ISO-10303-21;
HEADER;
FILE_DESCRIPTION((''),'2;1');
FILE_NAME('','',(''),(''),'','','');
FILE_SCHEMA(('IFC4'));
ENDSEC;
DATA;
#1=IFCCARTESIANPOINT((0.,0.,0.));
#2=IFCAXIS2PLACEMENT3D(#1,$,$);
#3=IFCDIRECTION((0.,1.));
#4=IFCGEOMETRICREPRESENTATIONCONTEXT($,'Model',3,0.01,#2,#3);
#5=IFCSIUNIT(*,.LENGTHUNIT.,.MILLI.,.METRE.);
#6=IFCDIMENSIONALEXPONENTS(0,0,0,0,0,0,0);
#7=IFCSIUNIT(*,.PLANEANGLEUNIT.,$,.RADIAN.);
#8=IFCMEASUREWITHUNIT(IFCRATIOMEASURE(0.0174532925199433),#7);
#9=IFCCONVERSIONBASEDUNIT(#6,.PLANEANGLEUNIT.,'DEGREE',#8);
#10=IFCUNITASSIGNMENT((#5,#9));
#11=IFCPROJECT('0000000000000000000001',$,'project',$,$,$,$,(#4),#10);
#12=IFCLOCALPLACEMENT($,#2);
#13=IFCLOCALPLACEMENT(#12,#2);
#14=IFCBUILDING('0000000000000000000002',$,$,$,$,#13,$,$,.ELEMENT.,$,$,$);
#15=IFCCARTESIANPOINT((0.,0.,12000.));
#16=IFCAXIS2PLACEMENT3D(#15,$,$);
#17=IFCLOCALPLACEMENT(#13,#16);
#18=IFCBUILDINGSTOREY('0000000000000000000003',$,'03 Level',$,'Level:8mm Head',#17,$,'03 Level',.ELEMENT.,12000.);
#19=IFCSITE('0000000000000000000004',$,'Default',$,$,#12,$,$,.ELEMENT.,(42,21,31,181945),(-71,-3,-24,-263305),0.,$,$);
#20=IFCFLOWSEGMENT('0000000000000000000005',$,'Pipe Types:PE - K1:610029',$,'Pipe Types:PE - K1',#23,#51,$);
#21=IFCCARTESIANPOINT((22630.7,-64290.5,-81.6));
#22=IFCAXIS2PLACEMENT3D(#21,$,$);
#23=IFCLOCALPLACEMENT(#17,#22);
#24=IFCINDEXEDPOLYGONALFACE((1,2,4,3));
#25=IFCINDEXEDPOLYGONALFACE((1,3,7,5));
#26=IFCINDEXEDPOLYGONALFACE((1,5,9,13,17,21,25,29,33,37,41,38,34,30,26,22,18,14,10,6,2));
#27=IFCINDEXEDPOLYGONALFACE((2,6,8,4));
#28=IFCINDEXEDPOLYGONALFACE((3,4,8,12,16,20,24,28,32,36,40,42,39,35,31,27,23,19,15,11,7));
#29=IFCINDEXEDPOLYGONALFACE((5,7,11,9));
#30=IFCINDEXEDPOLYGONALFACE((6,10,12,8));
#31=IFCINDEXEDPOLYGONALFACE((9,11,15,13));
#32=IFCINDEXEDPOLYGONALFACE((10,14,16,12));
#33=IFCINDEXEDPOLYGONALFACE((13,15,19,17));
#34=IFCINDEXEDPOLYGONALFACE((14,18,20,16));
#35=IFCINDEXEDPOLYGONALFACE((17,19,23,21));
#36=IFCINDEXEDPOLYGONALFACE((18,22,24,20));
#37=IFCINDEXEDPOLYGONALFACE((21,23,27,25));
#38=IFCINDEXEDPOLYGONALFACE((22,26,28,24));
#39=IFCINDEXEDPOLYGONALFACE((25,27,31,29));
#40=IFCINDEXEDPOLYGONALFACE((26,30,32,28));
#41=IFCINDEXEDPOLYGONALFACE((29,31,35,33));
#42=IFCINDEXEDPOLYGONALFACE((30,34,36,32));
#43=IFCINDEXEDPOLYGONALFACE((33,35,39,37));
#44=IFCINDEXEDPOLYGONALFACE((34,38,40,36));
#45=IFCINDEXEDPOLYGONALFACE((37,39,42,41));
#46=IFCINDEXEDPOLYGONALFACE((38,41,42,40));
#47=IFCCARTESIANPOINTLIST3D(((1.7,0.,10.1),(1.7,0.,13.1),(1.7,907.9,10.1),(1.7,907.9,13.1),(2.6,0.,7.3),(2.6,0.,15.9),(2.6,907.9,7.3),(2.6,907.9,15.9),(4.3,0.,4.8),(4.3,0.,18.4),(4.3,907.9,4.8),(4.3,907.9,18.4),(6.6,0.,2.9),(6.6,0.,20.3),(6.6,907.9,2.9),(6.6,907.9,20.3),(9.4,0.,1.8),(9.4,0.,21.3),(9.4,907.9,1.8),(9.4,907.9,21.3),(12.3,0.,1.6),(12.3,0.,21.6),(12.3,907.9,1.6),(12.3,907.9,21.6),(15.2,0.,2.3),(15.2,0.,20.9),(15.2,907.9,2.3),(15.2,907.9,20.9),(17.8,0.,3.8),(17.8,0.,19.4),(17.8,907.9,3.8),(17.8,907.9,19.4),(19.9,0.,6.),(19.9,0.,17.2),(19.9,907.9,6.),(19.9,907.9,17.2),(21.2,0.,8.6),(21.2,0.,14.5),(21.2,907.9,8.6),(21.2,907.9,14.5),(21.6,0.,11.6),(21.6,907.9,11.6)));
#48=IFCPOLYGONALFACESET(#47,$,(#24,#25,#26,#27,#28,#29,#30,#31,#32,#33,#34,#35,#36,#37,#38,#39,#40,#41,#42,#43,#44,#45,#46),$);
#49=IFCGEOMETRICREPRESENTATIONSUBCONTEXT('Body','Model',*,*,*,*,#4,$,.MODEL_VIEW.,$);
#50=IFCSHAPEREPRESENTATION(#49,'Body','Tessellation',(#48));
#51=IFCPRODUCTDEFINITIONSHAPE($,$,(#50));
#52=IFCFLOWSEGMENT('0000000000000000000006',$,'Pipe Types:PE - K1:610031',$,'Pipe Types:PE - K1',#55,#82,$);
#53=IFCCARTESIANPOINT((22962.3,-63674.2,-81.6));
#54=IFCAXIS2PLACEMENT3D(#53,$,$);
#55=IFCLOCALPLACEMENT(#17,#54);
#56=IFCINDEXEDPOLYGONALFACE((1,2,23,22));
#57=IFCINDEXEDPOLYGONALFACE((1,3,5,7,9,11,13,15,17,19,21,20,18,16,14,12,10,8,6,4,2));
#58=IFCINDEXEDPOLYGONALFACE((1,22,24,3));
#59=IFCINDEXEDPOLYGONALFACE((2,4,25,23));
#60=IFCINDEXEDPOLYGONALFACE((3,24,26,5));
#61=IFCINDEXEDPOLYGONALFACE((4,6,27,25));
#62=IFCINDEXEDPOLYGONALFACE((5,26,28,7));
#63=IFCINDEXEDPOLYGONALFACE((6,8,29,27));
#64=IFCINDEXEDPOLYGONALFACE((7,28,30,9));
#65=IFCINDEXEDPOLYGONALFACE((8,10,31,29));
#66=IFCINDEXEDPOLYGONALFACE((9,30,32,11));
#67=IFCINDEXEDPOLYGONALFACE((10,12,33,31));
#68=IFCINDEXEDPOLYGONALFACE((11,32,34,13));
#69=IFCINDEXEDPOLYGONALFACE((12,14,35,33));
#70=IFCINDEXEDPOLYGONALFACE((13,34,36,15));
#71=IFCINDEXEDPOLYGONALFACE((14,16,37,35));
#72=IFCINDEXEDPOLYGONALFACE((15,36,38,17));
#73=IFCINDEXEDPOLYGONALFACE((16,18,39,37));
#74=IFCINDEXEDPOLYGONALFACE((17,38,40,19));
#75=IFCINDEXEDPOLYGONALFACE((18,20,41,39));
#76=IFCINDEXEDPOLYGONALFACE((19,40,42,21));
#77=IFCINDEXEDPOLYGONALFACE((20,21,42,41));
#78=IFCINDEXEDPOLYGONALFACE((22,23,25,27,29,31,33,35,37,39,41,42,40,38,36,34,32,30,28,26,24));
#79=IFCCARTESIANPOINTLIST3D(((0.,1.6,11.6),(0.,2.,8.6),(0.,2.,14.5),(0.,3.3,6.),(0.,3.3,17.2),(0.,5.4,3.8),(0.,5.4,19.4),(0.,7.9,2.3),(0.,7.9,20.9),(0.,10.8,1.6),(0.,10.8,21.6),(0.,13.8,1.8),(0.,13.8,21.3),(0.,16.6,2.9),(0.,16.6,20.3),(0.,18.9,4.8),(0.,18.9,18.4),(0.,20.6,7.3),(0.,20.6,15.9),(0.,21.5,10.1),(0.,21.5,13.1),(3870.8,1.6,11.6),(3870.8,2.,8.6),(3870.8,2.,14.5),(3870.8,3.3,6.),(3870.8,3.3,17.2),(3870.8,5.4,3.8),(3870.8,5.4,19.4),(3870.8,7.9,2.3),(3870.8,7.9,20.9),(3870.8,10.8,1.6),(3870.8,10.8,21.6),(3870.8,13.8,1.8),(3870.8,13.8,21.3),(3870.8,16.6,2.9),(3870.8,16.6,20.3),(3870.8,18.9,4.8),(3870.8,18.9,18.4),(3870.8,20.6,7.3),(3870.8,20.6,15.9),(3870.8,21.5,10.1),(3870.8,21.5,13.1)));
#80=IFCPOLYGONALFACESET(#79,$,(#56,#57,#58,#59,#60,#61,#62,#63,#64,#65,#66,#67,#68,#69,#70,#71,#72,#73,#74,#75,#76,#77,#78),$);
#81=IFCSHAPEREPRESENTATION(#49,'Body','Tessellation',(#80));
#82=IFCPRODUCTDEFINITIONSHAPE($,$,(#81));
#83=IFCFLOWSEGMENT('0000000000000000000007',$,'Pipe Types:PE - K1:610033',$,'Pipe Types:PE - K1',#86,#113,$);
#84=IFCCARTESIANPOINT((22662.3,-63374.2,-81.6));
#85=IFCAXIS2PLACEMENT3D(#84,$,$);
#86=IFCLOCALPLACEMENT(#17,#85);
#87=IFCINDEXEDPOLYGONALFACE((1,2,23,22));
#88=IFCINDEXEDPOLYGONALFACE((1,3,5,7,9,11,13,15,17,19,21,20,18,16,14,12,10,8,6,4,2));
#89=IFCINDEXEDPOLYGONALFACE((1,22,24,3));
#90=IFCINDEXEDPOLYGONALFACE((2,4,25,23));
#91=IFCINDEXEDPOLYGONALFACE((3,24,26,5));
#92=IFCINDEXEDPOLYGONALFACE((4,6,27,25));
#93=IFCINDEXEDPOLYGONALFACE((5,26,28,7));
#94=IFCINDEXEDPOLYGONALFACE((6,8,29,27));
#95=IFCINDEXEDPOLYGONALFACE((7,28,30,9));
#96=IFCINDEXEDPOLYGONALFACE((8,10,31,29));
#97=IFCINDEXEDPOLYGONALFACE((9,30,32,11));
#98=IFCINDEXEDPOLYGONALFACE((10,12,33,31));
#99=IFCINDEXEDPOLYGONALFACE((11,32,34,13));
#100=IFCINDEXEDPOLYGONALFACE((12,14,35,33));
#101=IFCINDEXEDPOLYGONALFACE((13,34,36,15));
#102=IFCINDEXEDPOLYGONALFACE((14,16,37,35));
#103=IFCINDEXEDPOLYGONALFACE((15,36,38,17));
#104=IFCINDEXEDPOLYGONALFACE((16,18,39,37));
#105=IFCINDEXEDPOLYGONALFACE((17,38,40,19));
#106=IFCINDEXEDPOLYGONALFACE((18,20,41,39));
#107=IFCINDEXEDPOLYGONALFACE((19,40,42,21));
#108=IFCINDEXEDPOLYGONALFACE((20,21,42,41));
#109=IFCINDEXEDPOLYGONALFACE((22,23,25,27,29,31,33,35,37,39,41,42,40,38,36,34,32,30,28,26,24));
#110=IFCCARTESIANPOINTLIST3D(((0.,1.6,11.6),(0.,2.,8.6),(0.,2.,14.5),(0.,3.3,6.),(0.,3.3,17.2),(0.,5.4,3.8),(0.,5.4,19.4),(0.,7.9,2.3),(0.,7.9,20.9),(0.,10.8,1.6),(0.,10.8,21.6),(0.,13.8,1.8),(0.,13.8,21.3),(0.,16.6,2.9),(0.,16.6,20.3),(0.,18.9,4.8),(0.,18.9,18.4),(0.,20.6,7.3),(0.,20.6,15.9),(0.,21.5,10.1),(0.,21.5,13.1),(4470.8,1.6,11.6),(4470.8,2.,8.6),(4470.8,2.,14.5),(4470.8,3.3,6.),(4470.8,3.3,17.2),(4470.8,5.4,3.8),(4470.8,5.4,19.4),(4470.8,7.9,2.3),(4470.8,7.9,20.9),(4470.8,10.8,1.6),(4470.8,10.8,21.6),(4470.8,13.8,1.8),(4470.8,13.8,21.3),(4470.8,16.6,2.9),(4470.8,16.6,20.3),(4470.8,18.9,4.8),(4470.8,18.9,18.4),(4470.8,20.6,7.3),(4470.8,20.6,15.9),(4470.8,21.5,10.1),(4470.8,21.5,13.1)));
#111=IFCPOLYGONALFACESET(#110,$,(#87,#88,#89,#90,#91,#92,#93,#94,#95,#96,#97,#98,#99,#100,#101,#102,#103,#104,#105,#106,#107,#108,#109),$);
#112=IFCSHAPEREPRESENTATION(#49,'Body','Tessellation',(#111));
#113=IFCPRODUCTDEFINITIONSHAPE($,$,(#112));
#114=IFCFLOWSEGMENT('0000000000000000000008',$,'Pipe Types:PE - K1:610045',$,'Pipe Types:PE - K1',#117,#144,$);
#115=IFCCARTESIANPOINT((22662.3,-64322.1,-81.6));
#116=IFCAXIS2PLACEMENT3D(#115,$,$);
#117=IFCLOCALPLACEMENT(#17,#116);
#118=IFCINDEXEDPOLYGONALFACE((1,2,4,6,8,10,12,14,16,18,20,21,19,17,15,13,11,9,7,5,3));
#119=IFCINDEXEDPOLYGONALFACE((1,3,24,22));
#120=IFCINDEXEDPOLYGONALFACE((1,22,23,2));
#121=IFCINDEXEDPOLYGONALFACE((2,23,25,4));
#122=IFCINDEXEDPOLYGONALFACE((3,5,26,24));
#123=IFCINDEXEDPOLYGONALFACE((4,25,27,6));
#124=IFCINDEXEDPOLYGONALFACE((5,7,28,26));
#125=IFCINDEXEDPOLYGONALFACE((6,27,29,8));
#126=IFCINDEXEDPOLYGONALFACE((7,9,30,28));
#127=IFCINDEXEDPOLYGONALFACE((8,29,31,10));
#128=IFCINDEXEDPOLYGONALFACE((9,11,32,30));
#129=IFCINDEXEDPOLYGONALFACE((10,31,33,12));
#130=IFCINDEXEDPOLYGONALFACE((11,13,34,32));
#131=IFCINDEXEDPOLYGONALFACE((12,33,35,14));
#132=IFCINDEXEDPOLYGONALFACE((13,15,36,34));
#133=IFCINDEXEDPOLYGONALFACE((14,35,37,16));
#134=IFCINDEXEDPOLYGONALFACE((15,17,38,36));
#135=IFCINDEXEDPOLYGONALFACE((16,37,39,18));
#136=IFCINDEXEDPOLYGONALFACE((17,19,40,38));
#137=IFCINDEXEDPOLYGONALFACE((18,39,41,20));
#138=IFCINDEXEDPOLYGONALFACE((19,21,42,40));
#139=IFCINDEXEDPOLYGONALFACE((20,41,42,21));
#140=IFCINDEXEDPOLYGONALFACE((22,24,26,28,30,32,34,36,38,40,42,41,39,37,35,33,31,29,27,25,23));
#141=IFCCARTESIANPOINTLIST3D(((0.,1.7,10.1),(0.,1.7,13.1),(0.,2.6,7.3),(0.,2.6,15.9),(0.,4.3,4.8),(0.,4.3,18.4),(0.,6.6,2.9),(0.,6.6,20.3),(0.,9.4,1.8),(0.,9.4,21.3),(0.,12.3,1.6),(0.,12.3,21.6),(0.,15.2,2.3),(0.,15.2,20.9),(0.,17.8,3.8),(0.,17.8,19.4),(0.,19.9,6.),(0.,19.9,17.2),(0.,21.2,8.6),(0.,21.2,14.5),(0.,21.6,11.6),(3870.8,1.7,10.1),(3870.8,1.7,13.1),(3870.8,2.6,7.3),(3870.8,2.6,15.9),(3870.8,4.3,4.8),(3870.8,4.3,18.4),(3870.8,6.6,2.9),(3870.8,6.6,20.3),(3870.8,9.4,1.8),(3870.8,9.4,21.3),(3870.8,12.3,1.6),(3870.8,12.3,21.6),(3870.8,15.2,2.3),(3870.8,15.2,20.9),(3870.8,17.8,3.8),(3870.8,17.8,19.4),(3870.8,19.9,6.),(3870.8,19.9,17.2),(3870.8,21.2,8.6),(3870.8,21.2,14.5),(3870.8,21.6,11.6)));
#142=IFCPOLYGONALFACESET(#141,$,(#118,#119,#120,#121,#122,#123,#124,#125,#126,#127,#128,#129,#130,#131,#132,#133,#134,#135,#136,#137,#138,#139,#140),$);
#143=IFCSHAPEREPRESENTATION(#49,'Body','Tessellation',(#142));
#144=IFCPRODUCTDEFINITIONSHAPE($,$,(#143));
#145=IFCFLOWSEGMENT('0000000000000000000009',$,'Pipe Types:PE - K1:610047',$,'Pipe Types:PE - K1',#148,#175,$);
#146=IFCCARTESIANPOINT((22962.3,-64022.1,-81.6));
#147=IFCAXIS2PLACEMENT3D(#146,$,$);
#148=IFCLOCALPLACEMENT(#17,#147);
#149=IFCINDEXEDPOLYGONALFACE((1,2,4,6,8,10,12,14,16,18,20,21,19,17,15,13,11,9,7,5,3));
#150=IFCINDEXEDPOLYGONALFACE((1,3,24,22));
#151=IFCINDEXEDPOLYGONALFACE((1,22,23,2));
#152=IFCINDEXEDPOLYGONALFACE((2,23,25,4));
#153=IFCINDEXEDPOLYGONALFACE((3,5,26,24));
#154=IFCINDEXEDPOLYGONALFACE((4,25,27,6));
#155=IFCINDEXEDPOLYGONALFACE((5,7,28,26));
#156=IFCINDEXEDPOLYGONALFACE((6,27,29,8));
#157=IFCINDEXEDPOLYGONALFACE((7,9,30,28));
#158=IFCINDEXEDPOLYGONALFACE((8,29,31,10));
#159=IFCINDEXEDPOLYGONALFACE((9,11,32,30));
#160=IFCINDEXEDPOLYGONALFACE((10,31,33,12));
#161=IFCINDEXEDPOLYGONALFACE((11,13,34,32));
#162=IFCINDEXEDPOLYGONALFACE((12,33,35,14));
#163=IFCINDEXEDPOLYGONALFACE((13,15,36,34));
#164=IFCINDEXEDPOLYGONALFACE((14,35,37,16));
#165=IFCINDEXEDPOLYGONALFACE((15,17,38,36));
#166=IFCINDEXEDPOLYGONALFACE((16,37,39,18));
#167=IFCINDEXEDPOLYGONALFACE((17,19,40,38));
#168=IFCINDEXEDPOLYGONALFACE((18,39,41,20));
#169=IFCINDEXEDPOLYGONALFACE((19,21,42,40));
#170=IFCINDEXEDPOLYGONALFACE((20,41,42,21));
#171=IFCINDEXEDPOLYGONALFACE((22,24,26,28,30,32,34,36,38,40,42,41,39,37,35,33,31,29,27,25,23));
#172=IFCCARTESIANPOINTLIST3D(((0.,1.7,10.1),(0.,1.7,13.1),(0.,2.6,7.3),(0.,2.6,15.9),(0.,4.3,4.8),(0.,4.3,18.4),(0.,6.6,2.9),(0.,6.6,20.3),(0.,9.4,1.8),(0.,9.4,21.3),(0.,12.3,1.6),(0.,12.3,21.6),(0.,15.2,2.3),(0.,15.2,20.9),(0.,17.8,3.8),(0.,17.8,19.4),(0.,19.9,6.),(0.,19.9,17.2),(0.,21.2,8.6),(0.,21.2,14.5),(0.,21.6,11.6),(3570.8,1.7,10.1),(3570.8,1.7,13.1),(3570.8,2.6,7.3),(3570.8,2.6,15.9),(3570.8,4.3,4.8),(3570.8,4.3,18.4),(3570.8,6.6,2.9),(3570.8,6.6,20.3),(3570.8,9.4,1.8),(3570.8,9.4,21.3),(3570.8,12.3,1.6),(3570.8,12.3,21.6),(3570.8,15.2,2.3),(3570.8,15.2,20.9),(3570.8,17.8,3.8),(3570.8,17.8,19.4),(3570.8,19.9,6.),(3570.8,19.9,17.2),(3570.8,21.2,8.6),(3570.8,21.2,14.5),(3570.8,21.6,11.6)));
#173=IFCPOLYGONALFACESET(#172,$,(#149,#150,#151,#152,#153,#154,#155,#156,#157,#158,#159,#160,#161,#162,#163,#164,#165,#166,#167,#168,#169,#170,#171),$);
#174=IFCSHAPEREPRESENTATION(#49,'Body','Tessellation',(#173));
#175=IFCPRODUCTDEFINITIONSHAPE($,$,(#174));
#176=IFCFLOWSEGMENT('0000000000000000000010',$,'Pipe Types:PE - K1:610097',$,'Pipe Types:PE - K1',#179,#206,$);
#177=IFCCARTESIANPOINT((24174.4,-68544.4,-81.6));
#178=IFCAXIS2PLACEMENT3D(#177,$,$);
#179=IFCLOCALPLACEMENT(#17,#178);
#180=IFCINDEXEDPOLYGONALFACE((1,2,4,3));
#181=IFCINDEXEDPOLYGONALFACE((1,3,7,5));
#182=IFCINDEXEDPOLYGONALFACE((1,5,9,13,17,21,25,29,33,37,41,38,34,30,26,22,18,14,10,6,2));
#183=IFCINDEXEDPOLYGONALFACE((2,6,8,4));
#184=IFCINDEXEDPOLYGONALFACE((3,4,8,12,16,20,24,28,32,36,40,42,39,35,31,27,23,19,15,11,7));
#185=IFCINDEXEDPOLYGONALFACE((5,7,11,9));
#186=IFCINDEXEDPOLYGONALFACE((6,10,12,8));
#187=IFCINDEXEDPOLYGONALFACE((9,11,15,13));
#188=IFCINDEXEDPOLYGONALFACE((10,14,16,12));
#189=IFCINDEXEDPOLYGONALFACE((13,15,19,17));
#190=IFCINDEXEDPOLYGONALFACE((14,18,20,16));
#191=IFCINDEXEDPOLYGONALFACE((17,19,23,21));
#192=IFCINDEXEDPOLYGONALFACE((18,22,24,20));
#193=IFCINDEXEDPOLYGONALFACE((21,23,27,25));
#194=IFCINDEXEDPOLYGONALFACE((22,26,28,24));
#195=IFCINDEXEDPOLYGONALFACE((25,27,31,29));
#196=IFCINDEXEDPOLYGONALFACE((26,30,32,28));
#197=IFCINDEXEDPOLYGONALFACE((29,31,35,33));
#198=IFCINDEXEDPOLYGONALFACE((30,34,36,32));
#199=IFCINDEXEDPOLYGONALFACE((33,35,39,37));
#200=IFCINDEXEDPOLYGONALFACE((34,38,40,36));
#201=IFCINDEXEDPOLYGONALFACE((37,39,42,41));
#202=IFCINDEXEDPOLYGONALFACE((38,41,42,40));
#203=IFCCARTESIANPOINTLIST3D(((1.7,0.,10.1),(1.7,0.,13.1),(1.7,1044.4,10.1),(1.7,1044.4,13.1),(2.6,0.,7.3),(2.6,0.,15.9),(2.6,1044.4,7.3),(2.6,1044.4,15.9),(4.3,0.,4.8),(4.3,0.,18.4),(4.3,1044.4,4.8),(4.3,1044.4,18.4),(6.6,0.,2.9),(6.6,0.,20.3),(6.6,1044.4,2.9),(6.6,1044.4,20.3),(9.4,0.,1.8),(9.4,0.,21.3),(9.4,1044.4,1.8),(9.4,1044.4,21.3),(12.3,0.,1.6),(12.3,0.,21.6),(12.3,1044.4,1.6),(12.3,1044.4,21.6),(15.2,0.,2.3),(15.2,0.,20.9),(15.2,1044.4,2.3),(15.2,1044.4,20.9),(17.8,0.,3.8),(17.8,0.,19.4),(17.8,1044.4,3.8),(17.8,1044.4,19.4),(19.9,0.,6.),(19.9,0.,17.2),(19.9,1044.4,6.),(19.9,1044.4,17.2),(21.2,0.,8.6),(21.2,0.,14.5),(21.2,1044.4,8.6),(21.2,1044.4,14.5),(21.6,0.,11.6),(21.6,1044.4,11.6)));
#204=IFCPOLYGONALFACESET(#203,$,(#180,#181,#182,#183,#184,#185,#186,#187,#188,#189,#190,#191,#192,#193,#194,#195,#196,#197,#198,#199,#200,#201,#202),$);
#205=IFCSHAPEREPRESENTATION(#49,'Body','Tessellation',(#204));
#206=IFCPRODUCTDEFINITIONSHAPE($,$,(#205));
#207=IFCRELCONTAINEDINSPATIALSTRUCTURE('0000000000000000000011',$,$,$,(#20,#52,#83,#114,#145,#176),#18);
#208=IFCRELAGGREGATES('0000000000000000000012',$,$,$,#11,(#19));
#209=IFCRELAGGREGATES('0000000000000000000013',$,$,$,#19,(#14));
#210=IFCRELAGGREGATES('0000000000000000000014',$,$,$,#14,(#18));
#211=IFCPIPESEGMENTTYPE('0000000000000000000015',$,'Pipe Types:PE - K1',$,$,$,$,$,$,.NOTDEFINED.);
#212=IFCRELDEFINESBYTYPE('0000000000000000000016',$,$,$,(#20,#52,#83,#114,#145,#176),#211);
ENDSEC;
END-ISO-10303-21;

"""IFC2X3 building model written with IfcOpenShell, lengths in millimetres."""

from ifc_helpers import new_model, entity, si_unit, converted_unit, direction, frame, frame_2d, origin, origin_2d_with_axis, place, context, subcontext, project, spatial, circle, extrude, type_object, element, save


model = new_model("IFC2X3")

# Units and contexts
model_context = context("Model", 3, precision=0.01, world=origin(), true_north=direction((0.0, 1.0)))
body_context = subcontext(model_context, "Body", "Model", "MODEL_VIEW")
ifc_project = project(units=[si_unit("LENGTHUNIT", "METRE", prefix="MILLI"), converted_unit("PLANEANGLEUNIT", "DEGREE", entity("IfcRatioMeasure", 0.0174532925199433), si_unit("PLANEANGLEUNIT", "RADIAN"), dimensions=[0, 0, 0, 0, 0, 0, 0])], contexts=[model_context])

# Site, building, storey
site_placement = place(None, origin())
site = spatial("IfcSite", under=ifc_project, at=site_placement, Name="Default", CompositionType="ELEMENT", RefLatitude=(42, 21, 31, 181945), RefLongitude=(-71, -3, -24, -263305), RefElevation=0.0)
building_placement = place(site_placement, origin())
building = spatial("IfcBuilding", under=site, at=building_placement, CompositionType="ELEMENT")
storey_placement = place(building_placement, frame((0.0, 0.0, 12000.0)))
storey = spatial("IfcBuildingStorey", under=building, at=storey_placement, Name="03 Level", ObjectType="Level:8mm Head", LongName="03 Level", CompositionType="ELEMENT", Elevation=12000.0)

# Flow segments
pipe_segment_type = type_object("IfcPipeSegmentType", Name="Pipe Types:PE - K1", PredefinedType="NOTDEFINED")
flow_segment_1_placement = place(storey_placement, frame((22630.7, -64290.5, -81.6)))
element("IfcFlowSegment", 1, at=flow_segment_1_placement, inside=storey, type_object=pipe_segment_type, Name="Pipe Types:PE - K1:610029", ObjectType="Pipe Types:PE - K1", context=body_context, shape_type="SweptSolid", body=[
    extrude(circle(Radius=10.0, at=origin_2d_with_axis()), frame((11.6, 0.0, 11.6), z_axis=(0.0, 1.0, 0.0), x_axis=(1.0, 0.0, 0.0)), (0.0, 0.0, 1.0), 907.9),
])
flow_segment_2_placement = place(storey_placement, frame((22962.3, -63674.2, -81.6)))
element("IfcFlowSegment", 2, at=flow_segment_2_placement, inside=storey, type_object=pipe_segment_type, Name="Pipe Types:PE - K1:610031", ObjectType="Pipe Types:PE - K1", context=body_context, shape_type="SweptSolid", body=[
    extrude(circle(Radius=10.0, at=origin_2d_with_axis()), frame((0.0, 11.6, 11.6), z_axis=(1.0, 0.0, 0.0), x_axis=(0.0, -1.0, 0.0)), (0.0, 0.0, 1.0), 3870.8),
])
flow_segment_3_placement = place(storey_placement, frame((22662.3, -63374.2, -81.6)))
element("IfcFlowSegment", 3, at=flow_segment_3_placement, inside=storey, type_object=pipe_segment_type, Name="Pipe Types:PE - K1:610033", ObjectType="Pipe Types:PE - K1", context=body_context, shape_type="SweptSolid", body=[
    extrude(circle(Radius=10.0, at=origin_2d_with_axis()), frame((0.0, 11.6, 11.6), z_axis=(1.0, 0.0, 0.0), x_axis=(0.0, -1.0, 0.0)), (0.0, 0.0, 1.0), 4470.8),
])
flow_segment_4_placement = place(storey_placement, frame((22662.3, -64322.1, -81.6)))
element("IfcFlowSegment", 4, at=flow_segment_4_placement, inside=storey, type_object=pipe_segment_type, Name="Pipe Types:PE - K1:610045", ObjectType="Pipe Types:PE - K1", context=body_context, shape_type="SweptSolid", body=[
    extrude(circle(Radius=10.0, at=frame_2d((0.0, 0.0), x_axis=(1.0, 0.0))), frame((0.0, 11.6, 11.6), z_axis=(1.0, 0.0, 0.0), x_axis=(0.0, 1.0, 0.0)), (0.0, 0.0, 1.0), 3870.8),
])
flow_segment_5_placement = place(storey_placement, frame((22962.3, -64022.1, -81.6)))
element("IfcFlowSegment", 5, at=flow_segment_5_placement, inside=storey, type_object=pipe_segment_type, Name="Pipe Types:PE - K1:610047", ObjectType="Pipe Types:PE - K1", context=body_context, shape_type="SweptSolid", body=[
    extrude(circle(Radius=10.0, at=frame_2d((0.0, 0.0), x_axis=(1.0, 0.0))), frame((0.0, 11.6, 11.6), z_axis=(1.0, 0.0, 0.0), x_axis=(0.0, 1.0, 0.0)), (0.0, 0.0, 1.0), 3570.8),
])
flow_segment_6_placement = place(storey_placement, frame((24174.4, -68544.4, -81.6)))
element("IfcFlowSegment", 6, at=flow_segment_6_placement, inside=storey, type_object=pipe_segment_type, Name="Pipe Types:PE - K1:610097", ObjectType="Pipe Types:PE - K1", context=body_context, shape_type="SweptSolid", body=[
    extrude(circle(Radius=10.0, at=frame_2d((0.0, 0.0), x_axis=(1.0, 0.0))), frame((11.6, 0.0, 11.6), z_axis=(0.0, 1.0, 0.0), x_axis=(1.0, 0.0, 0.0)), (0.0, 0.0, 1.0), 1044.4),
])

save(model, "model.ifc")
